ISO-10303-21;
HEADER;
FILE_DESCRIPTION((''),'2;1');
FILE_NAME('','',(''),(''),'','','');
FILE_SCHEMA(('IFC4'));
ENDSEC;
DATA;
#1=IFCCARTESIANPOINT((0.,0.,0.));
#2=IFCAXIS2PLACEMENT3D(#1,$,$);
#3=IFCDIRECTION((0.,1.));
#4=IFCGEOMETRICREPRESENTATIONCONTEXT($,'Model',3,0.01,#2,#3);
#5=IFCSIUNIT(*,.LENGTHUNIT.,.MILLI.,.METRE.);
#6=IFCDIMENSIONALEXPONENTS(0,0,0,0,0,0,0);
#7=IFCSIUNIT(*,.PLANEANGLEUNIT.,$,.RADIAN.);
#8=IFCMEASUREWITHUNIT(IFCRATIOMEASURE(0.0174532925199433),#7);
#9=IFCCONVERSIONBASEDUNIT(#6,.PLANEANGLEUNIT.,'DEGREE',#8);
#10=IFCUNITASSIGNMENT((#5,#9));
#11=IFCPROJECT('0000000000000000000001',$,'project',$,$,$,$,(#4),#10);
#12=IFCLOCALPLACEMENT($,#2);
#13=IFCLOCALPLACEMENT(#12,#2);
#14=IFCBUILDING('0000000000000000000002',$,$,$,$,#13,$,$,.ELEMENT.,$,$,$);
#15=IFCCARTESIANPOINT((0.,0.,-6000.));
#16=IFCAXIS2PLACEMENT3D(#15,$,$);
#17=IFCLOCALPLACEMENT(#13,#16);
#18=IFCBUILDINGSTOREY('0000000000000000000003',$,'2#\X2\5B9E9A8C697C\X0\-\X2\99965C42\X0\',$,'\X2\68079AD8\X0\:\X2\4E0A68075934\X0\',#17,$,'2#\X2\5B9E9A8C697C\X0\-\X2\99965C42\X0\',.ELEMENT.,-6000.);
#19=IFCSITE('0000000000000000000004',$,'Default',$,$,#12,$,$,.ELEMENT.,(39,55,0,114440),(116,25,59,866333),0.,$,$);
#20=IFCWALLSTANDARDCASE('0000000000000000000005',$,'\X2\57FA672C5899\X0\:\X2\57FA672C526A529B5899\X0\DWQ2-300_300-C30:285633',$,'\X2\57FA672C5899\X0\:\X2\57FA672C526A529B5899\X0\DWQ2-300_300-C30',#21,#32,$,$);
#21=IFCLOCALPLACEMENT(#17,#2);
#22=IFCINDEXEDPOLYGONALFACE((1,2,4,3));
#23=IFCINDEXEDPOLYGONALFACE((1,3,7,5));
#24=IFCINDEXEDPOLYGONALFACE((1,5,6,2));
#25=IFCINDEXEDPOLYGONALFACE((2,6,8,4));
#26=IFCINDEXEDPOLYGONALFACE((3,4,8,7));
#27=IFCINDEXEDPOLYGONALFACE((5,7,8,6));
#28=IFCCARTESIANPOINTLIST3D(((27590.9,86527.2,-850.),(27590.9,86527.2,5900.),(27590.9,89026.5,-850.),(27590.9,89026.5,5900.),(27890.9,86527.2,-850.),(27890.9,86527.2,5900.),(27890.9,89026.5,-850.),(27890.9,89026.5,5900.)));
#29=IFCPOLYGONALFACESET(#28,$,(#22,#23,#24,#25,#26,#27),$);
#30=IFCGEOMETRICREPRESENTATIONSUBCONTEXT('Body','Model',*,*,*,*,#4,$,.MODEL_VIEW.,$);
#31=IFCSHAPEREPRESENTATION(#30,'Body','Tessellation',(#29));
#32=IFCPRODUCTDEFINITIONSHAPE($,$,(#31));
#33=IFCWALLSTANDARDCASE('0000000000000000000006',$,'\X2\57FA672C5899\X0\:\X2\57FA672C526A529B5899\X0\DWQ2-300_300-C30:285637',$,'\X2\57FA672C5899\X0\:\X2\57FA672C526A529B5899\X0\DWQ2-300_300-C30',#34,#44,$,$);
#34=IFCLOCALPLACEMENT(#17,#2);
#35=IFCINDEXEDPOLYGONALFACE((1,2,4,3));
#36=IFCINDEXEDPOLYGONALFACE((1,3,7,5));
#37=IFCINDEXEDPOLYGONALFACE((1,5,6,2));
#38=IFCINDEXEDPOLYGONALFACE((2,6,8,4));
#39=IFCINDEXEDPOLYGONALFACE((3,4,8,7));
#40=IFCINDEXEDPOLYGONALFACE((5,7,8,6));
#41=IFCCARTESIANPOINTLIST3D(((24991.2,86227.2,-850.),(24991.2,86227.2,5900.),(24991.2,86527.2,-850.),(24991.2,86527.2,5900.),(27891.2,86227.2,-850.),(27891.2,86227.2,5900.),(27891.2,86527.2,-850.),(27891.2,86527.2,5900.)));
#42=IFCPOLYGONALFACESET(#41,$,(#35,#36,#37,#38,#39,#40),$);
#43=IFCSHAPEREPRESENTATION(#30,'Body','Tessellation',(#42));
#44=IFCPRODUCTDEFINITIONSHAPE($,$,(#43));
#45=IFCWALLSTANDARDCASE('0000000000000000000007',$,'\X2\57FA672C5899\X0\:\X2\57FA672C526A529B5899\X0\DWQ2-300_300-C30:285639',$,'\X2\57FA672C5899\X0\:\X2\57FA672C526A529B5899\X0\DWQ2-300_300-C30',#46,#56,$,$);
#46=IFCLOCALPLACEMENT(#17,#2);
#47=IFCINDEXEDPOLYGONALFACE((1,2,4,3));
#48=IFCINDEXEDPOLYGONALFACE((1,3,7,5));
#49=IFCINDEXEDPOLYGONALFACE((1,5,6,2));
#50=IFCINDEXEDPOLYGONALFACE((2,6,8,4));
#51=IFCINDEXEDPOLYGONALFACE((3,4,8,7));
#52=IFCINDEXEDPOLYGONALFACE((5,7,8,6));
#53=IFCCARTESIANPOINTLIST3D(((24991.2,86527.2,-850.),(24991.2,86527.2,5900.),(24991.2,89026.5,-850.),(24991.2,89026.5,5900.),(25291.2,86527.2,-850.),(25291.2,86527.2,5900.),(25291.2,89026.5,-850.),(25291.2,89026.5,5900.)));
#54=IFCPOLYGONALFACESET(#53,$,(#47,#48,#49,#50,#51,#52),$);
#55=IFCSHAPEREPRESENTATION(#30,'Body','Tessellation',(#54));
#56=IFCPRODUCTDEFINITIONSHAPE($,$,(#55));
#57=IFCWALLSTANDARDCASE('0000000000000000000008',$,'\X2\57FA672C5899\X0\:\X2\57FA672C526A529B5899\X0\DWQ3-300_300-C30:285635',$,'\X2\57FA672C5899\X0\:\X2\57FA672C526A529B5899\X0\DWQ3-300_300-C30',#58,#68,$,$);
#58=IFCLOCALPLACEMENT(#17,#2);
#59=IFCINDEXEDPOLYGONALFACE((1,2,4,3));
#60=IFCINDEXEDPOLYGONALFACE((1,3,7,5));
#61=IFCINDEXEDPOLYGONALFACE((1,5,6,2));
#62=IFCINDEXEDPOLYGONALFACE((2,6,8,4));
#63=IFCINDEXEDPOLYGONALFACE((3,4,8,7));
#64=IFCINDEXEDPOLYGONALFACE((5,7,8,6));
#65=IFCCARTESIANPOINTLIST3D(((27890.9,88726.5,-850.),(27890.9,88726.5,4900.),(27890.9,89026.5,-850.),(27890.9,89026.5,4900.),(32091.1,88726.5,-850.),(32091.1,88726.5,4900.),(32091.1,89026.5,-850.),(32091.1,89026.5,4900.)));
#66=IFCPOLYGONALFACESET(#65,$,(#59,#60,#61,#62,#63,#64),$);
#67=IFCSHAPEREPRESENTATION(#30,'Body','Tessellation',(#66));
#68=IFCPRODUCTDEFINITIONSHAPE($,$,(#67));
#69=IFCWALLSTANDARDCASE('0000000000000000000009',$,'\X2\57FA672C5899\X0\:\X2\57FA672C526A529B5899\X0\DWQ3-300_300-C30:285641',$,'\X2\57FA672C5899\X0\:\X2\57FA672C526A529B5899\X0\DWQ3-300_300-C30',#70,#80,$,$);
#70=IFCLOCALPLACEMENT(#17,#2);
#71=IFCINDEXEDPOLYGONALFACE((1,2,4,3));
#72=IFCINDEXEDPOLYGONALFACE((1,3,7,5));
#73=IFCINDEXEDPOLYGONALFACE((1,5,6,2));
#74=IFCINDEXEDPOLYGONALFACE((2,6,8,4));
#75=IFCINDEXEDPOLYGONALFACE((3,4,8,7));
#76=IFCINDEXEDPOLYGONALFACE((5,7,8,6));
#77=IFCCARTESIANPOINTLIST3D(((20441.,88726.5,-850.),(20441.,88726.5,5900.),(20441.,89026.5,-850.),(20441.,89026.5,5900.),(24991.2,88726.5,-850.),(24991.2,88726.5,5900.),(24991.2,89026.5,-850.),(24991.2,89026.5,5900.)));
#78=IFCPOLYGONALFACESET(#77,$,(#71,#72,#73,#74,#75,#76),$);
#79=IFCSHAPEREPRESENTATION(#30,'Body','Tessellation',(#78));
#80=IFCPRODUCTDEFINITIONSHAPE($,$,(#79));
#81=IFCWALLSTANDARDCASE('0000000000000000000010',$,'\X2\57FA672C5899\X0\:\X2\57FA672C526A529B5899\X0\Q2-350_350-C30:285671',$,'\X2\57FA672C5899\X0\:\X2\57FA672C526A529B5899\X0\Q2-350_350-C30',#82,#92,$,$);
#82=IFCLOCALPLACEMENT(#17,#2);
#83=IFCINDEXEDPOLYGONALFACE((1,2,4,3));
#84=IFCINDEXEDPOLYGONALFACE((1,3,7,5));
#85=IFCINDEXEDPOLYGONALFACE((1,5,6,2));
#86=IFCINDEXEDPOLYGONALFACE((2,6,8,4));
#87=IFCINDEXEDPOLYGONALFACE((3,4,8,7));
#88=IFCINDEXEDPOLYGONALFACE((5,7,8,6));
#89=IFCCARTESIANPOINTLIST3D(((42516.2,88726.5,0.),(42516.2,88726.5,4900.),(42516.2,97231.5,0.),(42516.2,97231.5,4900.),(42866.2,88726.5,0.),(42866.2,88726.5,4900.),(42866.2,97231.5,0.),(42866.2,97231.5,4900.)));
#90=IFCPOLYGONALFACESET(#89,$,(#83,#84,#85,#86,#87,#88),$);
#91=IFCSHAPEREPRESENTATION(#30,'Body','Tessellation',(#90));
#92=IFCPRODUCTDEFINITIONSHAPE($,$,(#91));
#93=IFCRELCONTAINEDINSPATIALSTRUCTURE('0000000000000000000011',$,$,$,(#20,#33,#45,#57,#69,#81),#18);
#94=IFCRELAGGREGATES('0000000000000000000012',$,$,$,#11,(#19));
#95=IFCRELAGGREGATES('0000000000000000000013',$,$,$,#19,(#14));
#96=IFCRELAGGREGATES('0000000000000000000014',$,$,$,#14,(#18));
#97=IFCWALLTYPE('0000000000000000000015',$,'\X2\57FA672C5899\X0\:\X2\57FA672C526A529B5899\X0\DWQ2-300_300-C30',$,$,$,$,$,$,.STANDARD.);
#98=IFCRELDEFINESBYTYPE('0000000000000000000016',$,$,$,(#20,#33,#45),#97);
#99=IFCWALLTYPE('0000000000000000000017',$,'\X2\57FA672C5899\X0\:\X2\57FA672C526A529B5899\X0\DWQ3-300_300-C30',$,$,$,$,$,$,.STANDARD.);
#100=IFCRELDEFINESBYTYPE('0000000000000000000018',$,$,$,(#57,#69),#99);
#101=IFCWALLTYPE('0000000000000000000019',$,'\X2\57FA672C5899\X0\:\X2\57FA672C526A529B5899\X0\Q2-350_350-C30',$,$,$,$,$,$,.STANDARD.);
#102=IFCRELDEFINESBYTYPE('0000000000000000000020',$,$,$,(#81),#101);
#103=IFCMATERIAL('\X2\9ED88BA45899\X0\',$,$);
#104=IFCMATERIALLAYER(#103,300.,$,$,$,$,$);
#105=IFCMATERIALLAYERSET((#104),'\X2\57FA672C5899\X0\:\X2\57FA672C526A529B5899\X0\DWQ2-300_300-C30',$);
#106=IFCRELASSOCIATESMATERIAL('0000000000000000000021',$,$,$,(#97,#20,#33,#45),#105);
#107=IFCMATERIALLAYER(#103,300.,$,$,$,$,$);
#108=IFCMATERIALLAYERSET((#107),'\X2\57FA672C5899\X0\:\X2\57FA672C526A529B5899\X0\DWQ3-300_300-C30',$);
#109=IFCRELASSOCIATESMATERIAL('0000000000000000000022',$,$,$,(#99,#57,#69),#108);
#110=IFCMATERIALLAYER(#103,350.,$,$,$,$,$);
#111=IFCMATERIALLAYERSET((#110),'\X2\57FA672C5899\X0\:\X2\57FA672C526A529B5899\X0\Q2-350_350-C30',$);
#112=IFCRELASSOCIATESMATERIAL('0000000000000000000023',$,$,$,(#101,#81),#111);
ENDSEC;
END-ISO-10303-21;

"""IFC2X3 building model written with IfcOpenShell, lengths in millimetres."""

from ifc_helpers import new_model, entity, si_unit, converted_unit, direction, frame, frame_2d, origin, place, context, subcontext, project, spatial, rectangle, extrude, material, layer, layer_set, layer_usage, type_object, element, save


model = new_model("IFC2X3")

# Units and contexts
model_context = context("Model", 3, precision=0.01, world=origin(), true_north=direction((0.0, 1.0)))
body_context = subcontext(model_context, "Body", "Model", "MODEL_VIEW")
ifc_project = project(units=[si_unit("LENGTHUNIT", "METRE", prefix="MILLI"), converted_unit("PLANEANGLEUNIT", "DEGREE", entity("IfcRatioMeasure", 0.0174532925199433), si_unit("PLANEANGLEUNIT", "RADIAN"), dimensions=[0, 0, 0, 0, 0, 0, 0])], contexts=[model_context])

# Site, building, storey
site_placement = place(None, origin())
site = spatial("IfcSite", under=ifc_project, at=site_placement, Name="Default", CompositionType="ELEMENT", RefLatitude=(39, 55, 0, 114440), RefLongitude=(116, 25, 59, 866333), RefElevation=0.0)
building_placement = place(site_placement, origin())
building = spatial("IfcBuilding", under=site, at=building_placement, CompositionType="ELEMENT")
storey_placement = place(building_placement, frame((0.0, 0.0, -6000.0)))
storey = spatial("IfcBuildingStorey", under=building, at=storey_placement, Name="2#实验楼-首层", ObjectType="标高:上标头", LongName="2#实验楼-首层", CompositionType="ELEMENT", Elevation=-6000.0)

# Walls
ifc_material_1 = material(Name="默认墙")
ifc_layer_1 = layer(ifc_material_1, 300.0)
ifc_layer_set_1 = layer_set([ifc_layer_1], Name="基本墙:基本剪力墙DWQ2-300_300-C30")
ifc_layer_usage_1 = layer_usage(ifc_layer_set_1, "AXIS2", "NEGATIVE", 150.0)
wall_type_1 = type_object("IfcWallType", Name="基本墙:基本剪力墙DWQ2-300_300-C30", PredefinedType="STANDARD", material=ifc_layer_set_1)
wall_1_placement = place(storey_placement, frame((27740.9, 86527.2, -850.0), z_axis=(0.0, 0.0, 1.0), x_axis=(0.0, 1.0, 0.0)))
element("IfcWallStandardCase", 1, at=wall_1_placement, inside=storey, type_object=wall_type_1, material=ifc_layer_usage_1, Name="基本墙:基本剪力墙DWQ2-300_300-C30:285633", ObjectType="基本墙:基本剪力墙DWQ2-300_300-C30", context=body_context, shape_type="SweptSolid", body=[
    extrude(rectangle(XDim=2499.4, YDim=300.0, at=frame_2d((1249.7, 0.0), x_axis=(-1.0, 0.0))), origin(), (0.0, 0.0, 1.0), 6750.0),
])
ifc_layer_usage_2 = layer_usage(ifc_layer_set_1, "AXIS2", "NEGATIVE", 150.0)
wall_2_placement = place(storey_placement, frame((24991.2, 86377.2, -850.0)))
element("IfcWallStandardCase", 2, at=wall_2_placement, inside=storey, type_object=wall_type_1, material=ifc_layer_usage_2, Name="基本墙:基本剪力墙DWQ2-300_300-C30:285637", ObjectType="基本墙:基本剪力墙DWQ2-300_300-C30", context=body_context, shape_type="SweptSolid", body=[
    extrude(rectangle(XDim=2900.0, YDim=300.0, at=frame_2d((1450.0, 0.0), x_axis=(-1.0, 0.0))), origin(), (0.0, 0.0, 1.0), 6750.0),
])
ifc_layer_usage_3 = layer_usage(ifc_layer_set_1, "AXIS2", "NEGATIVE", 150.0)
wall_3_placement = place(storey_placement, frame((25141.2, 89026.5, -850.0), z_axis=(0.0, 0.0, 1.0), x_axis=(0.0, -1.0, 0.0)))
element("IfcWallStandardCase", 3, at=wall_3_placement, inside=storey, type_object=wall_type_1, material=ifc_layer_usage_3, Name="基本墙:基本剪力墙DWQ2-300_300-C30:285639", ObjectType="基本墙:基本剪力墙DWQ2-300_300-C30", context=body_context, shape_type="SweptSolid", body=[
    extrude(rectangle(XDim=2499.4, YDim=300.0, at=frame_2d((1249.7, 0.0), x_axis=(-1.0, 0.0))), origin(), (0.0, 0.0, 1.0), 6750.0),
])
ifc_layer_2 = layer(ifc_material_1, 300.0)
ifc_layer_set_2 = layer_set([ifc_layer_2], Name="基本墙:基本剪力墙DWQ3-300_300-C30")
ifc_layer_usage_4 = layer_usage(ifc_layer_set_2, "AXIS2", "NEGATIVE", 150.0)
wall_type_2 = type_object("IfcWallType", Name="基本墙:基本剪力墙DWQ3-300_300-C30", PredefinedType="STANDARD", material=ifc_layer_set_2)
wall_4_placement = place(storey_placement, frame((27890.9, 88876.5, -850.0)))
element("IfcWallStandardCase", 4, at=wall_4_placement, inside=storey, type_object=wall_type_2, material=ifc_layer_usage_4, Name="基本墙:基本剪力墙DWQ3-300_300-C30:285635", ObjectType="基本墙:基本剪力墙DWQ3-300_300-C30", context=body_context, shape_type="SweptSolid", body=[
    extrude(rectangle(XDim=4200.2, YDim=300.0, at=frame_2d((2100.1, 0.0), x_axis=(-1.0, 0.0))), origin(), (0.0, 0.0, 1.0), 5750.0),
])
ifc_layer_usage_5 = layer_usage(ifc_layer_set_2, "AXIS2", "NEGATIVE", 150.0)
wall_5_placement = place(storey_placement, frame((20441.0, 88876.5, -850.0)))
element("IfcWallStandardCase", 5, at=wall_5_placement, inside=storey, type_object=wall_type_2, material=ifc_layer_usage_5, Name="基本墙:基本剪力墙DWQ3-300_300-C30:285641", ObjectType="基本墙:基本剪力墙DWQ3-300_300-C30", context=body_context, shape_type="SweptSolid", body=[
    extrude(rectangle(XDim=4550.2, YDim=300.0, at=frame_2d((2275.1, 0.0), x_axis=(-1.0, 0.0))), origin(), (0.0, 0.0, 1.0), 6750.0),
])
ifc_layer_3 = layer(ifc_material_1, 350.0)
ifc_layer_set_3 = layer_set([ifc_layer_3], Name="基本墙:基本剪力墙Q2-350_350-C30")
ifc_layer_usage_6 = layer_usage(ifc_layer_set_3, "AXIS2", "NEGATIVE", 175.0)
wall_type_3 = type_object("IfcWallType", Name="基本墙:基本剪力墙Q2-350_350-C30", PredefinedType="STANDARD", material=ifc_layer_set_3)
wall_6_placement = place(storey_placement, frame((42691.2, 88726.5, 0.0), z_axis=(0.0, 0.0, 1.0), x_axis=(0.000002, 1.0, 0.0)))
element("IfcWallStandardCase", 6, at=wall_6_placement, inside=storey, type_object=wall_type_3, material=ifc_layer_usage_6, Name="基本墙:基本剪力墙Q2-350_350-C30:285671", ObjectType="基本墙:基本剪力墙Q2-350_350-C30", context=body_context, shape_type="SweptSolid", body=[
    extrude(rectangle(XDim=8505.0, YDim=350.0, at=frame_2d((4252.5, 0.0), x_axis=(-1.0, 0.0))), origin(), (0.0, 0.0, 1.0), 4900.0),
])

save(model, "model.ifc")
